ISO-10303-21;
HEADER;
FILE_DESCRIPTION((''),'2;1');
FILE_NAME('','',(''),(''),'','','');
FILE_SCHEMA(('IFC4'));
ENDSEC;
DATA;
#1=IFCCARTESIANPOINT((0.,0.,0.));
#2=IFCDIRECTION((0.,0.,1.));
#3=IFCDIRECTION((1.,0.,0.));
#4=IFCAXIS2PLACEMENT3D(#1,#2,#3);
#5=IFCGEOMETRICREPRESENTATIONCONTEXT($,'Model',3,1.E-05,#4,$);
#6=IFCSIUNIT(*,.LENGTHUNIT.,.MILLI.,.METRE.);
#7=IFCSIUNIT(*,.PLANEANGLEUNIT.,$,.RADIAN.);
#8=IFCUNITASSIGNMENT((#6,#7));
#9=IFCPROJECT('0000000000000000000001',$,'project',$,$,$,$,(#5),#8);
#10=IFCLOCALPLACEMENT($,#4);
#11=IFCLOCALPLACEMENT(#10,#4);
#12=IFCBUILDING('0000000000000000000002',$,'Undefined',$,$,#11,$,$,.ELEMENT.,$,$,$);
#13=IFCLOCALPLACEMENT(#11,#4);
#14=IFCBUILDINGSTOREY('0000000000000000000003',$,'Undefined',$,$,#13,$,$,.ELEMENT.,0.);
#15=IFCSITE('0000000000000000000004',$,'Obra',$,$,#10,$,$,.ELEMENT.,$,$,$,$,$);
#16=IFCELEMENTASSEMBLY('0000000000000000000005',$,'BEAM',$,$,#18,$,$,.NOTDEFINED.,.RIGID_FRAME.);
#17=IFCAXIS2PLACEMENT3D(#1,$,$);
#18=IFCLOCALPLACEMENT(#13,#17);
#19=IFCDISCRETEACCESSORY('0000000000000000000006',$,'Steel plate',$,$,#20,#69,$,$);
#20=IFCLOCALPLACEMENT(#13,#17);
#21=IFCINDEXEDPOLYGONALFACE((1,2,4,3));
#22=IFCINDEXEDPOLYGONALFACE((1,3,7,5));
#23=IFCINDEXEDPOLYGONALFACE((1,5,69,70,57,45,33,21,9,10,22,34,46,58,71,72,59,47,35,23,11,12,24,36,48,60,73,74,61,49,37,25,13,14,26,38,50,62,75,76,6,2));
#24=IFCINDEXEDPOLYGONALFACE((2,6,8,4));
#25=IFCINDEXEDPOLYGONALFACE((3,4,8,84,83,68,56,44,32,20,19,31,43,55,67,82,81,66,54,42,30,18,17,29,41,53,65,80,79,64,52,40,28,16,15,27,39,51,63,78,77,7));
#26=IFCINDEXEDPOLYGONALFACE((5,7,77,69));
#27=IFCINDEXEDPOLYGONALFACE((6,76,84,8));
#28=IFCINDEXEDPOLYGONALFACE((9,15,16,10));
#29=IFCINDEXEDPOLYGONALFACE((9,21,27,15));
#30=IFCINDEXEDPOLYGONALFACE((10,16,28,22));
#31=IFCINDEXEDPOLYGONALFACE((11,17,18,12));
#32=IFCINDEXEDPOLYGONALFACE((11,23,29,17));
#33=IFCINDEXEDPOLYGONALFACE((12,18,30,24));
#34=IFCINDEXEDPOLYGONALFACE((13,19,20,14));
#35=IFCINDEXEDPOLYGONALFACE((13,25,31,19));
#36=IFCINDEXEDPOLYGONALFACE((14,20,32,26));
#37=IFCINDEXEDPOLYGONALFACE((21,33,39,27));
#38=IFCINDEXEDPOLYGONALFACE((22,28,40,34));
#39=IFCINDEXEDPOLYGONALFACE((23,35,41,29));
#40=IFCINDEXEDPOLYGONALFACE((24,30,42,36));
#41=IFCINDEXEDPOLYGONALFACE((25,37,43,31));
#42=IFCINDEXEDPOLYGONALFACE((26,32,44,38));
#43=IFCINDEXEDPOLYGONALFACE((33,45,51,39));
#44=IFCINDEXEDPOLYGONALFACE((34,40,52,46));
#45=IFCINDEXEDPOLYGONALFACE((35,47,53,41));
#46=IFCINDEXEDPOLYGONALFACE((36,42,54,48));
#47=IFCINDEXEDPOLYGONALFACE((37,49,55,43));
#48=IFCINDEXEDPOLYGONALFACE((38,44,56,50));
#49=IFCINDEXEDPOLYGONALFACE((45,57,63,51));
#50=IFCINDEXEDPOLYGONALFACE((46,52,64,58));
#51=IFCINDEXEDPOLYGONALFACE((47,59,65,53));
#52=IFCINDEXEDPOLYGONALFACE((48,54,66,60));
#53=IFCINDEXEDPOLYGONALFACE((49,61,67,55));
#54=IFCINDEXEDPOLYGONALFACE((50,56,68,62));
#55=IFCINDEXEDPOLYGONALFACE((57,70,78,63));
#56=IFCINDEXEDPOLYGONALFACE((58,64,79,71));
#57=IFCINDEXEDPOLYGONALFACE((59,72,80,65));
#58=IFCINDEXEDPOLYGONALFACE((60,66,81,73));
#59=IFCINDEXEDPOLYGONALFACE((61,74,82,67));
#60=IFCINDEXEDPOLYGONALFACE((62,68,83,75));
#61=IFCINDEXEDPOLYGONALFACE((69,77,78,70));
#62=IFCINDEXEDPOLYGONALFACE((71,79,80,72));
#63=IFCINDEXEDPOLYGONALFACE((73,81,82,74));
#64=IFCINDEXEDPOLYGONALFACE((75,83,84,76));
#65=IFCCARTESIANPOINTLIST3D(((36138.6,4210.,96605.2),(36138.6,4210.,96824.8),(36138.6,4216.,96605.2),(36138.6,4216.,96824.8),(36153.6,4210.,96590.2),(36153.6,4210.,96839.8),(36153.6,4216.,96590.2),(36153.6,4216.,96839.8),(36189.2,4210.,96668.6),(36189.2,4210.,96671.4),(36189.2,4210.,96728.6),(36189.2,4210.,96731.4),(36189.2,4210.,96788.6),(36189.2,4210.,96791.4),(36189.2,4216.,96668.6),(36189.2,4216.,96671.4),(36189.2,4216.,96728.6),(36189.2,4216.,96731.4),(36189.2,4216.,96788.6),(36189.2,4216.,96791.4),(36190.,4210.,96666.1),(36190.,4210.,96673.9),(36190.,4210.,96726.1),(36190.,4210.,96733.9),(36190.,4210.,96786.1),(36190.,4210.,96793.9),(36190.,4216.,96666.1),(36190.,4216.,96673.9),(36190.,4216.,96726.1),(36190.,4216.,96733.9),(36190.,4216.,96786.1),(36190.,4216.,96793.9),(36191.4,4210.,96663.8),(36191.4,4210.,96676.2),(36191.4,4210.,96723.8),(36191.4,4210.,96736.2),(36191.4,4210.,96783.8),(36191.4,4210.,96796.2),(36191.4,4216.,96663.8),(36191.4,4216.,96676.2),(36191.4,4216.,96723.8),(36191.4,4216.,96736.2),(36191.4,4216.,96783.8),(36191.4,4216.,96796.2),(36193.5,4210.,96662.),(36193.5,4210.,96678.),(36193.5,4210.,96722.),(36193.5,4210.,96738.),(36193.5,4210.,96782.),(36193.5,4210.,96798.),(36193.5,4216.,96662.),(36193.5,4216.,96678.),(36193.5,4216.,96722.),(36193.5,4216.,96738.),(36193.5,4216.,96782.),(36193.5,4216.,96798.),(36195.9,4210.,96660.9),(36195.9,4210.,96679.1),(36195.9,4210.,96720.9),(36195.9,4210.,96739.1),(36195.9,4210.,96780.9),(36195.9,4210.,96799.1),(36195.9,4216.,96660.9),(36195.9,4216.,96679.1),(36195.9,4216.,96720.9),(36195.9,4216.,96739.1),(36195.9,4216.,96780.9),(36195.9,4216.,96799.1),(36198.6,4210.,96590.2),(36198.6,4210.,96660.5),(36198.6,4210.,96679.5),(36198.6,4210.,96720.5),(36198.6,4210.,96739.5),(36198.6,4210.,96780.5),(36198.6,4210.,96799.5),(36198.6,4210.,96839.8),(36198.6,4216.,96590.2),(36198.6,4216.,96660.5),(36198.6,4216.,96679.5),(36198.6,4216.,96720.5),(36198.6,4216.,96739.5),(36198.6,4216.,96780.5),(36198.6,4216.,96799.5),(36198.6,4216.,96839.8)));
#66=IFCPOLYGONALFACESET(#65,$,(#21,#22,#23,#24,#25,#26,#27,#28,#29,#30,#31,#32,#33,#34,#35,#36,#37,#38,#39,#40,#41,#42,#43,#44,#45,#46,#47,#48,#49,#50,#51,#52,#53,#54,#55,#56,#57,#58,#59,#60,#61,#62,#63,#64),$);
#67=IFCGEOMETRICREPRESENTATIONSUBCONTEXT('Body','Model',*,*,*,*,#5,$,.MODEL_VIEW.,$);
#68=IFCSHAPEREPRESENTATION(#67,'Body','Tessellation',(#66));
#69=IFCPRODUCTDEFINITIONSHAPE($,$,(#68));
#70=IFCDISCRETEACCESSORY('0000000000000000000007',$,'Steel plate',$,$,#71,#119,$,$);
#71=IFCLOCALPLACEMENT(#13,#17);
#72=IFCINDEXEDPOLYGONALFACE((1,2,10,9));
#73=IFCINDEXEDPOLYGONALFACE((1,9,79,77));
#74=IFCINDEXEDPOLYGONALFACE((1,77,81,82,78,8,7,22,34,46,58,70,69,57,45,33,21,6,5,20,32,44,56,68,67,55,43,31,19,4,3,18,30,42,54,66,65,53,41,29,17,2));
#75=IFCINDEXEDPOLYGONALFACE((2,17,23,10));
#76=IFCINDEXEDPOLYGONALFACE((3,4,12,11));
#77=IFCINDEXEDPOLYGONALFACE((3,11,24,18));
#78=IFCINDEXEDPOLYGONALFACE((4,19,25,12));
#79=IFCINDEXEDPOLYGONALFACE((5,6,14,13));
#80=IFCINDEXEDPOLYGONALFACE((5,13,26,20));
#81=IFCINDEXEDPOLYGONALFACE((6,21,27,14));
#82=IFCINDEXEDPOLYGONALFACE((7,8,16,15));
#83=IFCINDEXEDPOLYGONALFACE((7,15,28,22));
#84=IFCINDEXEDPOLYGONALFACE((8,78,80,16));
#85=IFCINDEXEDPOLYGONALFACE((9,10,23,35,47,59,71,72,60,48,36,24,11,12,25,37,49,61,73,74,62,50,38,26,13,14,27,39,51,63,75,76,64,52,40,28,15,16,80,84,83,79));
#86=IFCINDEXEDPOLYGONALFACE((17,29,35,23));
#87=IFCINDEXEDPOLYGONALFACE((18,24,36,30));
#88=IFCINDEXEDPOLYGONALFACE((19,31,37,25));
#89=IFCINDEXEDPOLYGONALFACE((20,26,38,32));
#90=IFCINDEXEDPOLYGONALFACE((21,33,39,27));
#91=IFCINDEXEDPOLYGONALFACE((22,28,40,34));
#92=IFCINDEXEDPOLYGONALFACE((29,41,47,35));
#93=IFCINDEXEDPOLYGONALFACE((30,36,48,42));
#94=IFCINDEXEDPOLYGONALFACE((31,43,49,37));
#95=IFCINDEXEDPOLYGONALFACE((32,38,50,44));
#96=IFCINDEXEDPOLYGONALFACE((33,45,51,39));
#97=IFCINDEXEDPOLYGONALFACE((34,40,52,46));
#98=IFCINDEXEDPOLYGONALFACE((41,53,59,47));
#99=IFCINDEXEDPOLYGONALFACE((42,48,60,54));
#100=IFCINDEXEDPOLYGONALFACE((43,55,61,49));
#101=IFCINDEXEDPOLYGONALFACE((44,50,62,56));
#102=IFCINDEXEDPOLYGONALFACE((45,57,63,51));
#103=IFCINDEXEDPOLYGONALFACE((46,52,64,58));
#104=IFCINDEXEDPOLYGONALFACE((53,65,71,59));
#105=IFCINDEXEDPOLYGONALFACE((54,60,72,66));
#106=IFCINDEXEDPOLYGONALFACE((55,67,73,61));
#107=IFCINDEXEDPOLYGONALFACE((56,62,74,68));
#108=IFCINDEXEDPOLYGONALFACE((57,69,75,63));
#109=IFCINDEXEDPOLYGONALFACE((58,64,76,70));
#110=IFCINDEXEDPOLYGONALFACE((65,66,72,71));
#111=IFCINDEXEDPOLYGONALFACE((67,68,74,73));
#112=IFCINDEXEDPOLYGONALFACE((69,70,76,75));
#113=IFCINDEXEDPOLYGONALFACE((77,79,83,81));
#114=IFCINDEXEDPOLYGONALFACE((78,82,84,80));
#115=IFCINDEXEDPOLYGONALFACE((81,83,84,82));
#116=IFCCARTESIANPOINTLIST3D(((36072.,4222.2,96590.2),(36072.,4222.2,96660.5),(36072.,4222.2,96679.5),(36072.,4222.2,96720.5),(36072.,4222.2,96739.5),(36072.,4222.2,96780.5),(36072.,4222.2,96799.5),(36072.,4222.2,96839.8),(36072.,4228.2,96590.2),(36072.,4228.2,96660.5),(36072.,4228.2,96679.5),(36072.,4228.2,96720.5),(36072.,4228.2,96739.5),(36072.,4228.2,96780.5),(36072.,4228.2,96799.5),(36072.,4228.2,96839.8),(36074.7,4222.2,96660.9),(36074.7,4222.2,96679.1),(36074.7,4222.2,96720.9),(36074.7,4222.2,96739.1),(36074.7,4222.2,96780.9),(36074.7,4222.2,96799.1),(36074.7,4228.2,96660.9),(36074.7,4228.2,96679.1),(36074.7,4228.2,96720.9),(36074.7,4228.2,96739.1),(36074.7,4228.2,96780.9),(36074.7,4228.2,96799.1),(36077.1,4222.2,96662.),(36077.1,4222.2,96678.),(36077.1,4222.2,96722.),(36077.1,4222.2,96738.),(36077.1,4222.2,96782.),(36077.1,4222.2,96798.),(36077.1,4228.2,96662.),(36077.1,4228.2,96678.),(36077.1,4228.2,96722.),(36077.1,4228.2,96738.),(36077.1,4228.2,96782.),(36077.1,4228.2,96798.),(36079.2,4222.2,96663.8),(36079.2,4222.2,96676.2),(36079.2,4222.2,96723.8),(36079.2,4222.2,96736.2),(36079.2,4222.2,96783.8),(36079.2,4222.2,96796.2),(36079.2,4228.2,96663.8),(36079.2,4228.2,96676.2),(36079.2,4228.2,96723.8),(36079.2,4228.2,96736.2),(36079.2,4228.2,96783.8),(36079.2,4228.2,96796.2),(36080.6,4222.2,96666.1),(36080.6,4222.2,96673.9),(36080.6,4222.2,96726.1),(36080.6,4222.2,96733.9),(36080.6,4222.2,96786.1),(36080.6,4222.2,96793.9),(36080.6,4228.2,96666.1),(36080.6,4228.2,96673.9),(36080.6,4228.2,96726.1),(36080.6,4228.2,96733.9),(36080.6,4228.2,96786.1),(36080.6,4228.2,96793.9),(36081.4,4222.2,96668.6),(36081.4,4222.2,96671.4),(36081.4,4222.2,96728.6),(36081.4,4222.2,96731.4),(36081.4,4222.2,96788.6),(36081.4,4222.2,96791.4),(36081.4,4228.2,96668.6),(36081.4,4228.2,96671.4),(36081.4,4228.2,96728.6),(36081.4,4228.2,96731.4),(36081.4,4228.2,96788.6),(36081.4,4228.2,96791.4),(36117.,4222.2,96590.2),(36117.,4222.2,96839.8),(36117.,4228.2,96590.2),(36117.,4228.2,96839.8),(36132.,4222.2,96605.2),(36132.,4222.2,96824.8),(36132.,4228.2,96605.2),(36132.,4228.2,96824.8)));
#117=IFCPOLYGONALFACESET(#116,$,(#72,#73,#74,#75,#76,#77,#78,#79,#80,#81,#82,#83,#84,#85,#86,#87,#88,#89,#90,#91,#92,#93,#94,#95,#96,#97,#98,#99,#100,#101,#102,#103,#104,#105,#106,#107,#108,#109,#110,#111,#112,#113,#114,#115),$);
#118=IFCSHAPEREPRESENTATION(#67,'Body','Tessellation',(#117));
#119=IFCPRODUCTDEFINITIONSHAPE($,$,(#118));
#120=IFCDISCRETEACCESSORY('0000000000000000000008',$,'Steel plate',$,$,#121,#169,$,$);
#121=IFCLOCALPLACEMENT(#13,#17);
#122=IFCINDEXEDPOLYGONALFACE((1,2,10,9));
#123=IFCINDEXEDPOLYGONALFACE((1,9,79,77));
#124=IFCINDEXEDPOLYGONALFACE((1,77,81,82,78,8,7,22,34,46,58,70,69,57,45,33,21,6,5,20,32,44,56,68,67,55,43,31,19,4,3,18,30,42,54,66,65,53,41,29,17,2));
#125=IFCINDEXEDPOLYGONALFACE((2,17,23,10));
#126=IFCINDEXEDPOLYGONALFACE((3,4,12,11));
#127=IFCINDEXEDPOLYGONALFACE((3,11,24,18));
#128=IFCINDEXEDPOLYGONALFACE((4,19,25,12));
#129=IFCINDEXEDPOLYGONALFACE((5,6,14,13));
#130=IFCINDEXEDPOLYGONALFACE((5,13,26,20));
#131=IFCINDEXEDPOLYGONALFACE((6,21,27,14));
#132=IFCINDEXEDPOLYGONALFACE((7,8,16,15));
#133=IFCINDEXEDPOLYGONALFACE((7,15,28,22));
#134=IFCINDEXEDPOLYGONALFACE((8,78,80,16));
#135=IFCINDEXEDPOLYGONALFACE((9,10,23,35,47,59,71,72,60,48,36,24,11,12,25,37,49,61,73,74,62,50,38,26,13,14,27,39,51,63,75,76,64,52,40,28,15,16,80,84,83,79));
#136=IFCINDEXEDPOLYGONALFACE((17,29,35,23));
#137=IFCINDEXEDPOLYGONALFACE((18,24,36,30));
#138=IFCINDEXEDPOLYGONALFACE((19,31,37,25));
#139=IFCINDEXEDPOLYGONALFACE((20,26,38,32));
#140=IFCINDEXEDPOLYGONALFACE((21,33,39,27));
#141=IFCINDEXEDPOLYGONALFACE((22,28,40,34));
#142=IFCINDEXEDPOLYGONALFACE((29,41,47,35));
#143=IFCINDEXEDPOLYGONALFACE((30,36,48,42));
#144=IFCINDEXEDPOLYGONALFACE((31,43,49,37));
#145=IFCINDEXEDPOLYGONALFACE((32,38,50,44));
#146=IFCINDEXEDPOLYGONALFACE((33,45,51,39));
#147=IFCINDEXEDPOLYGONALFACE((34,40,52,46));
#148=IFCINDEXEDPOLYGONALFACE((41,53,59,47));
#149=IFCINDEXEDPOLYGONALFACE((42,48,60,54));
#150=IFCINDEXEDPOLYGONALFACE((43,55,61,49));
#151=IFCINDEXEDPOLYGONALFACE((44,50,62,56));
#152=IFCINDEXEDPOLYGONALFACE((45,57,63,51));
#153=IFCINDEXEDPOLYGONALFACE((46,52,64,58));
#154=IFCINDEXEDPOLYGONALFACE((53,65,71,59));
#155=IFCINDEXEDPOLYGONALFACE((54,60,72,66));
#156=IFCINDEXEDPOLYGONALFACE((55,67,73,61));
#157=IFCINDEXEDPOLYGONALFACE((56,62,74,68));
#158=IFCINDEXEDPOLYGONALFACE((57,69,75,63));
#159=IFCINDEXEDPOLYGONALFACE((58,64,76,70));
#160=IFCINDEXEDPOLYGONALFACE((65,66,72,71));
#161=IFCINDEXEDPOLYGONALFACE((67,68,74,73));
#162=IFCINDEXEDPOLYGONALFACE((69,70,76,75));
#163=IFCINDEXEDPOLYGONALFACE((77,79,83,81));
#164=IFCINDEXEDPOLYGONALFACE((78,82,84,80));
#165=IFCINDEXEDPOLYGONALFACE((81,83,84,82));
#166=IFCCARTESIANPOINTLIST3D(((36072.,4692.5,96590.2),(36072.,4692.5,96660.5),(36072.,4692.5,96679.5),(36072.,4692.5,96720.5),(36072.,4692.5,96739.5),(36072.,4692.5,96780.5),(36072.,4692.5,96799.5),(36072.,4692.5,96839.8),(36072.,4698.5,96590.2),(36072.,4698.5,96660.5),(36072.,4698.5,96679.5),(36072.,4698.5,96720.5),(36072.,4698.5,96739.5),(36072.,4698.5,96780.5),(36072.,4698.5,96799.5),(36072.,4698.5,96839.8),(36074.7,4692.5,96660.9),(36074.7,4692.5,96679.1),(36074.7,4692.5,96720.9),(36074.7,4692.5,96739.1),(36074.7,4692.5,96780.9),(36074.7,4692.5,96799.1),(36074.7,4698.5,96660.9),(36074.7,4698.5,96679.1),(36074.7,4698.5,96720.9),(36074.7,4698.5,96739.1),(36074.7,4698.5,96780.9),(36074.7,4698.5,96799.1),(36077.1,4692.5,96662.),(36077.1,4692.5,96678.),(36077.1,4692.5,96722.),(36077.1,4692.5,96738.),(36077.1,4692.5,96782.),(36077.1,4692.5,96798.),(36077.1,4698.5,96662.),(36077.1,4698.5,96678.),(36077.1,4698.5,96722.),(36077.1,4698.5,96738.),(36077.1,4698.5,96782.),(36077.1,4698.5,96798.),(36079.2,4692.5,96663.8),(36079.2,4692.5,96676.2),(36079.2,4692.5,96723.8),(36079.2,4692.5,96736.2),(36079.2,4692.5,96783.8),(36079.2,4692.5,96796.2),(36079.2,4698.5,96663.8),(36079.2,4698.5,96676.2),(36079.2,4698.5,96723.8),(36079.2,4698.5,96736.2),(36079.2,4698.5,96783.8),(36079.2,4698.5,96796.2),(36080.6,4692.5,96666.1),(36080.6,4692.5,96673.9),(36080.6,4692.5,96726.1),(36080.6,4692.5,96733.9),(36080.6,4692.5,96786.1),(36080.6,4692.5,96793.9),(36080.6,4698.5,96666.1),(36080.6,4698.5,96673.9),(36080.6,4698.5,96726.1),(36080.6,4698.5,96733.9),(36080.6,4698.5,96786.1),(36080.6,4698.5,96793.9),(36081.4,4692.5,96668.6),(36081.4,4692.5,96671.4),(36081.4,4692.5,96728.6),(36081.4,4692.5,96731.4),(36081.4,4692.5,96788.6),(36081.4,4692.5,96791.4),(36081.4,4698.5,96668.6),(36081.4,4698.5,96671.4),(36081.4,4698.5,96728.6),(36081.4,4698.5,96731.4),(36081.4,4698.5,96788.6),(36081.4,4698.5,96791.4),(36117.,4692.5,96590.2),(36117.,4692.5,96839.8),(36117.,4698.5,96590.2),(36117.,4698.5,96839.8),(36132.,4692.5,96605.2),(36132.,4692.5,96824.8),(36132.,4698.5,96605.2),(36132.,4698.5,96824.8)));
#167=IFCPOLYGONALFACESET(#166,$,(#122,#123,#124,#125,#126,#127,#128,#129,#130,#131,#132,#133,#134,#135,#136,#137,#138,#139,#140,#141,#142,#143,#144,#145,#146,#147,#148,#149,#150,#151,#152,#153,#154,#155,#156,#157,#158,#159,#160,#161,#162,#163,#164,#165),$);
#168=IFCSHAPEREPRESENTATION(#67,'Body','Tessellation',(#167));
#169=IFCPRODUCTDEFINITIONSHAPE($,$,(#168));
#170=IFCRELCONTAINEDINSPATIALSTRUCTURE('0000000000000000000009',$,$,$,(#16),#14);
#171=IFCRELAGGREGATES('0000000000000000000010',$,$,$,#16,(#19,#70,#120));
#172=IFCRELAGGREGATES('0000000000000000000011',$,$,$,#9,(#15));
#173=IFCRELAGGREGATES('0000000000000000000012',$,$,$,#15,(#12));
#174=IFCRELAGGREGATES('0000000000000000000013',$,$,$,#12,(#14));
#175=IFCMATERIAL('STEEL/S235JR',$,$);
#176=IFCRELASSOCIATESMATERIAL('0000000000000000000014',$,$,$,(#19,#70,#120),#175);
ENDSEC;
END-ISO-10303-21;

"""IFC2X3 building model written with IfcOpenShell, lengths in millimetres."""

from ifc_helpers import new_model, si_unit, frame, origin_with_axes, origin_2d_with_axis, place, context, subcontext, project, spatial, polyline, circle, outline, extrude, source, transform, mapped, material, element, aggregate, save


model = new_model("IFC2X3")

# Units and contexts
model_context = context("Model", 3, precision=1e-05, world=origin_with_axes())
body_context = subcontext(model_context, "Body", "Model", "MODEL_VIEW")
ifc_project = project(units=[si_unit("LENGTHUNIT", "METRE", prefix="MILLI"), si_unit("PLANEANGLEUNIT", "RADIAN")], contexts=[model_context])

# Site, building, storey
site_placement = place(None, origin_with_axes())
site = spatial("IfcSite", under=ifc_project, at=site_placement, Name="Obra", CompositionType="ELEMENT")
building_placement = place(site_placement, origin_with_axes())
building = spatial("IfcBuilding", under=site, at=building_placement, Name="Undefined", CompositionType="ELEMENT")
storey_placement = place(building_placement, origin_with_axes())
storey = spatial("IfcBuildingStorey", under=building, at=storey_placement, Name="Undefined", CompositionType="ELEMENT", Elevation=0.0)

# Shared definitions
ifc_material = material(Name="STEEL/S235JR")

# Element assembly, discrete accessories, openings
shared_shape = source(origin_with_axes(), body_context, "Body", "SweptSolid", [
    extrude(circle(Radius=9.5, at=origin_2d_with_axis()), frame((0.0, -9.2, 0.0), z_axis=(0.0, 1.0, 0.0), x_axis=(1.0, 0.0, 0.0)), (0.0, 0.0, 1.0), 6.2),
])
assembly_1_placement = place(storey_placement, origin_with_axes())
assembly_1 = element("IfcElementAssembly", 1, at=assembly_1_placement, inside=storey, Name="BEAM", AssemblyPlace="NOTDEFINED", PredefinedType="RIGID_FRAME")
discrete_accessory_1_placement = place(assembly_1_placement, frame((36198.6, 4213.0, 96590.2), z_axis=(0.0, 1.0, 0.0), x_axis=(-1.0, 0.0, 0.0)))
discrete_accessory_1 = element("IfcDiscreteAccessory", 2, at=discrete_accessory_1_placement, material=ifc_material, Name="Steel plate", context=body_context, shape_type="SweptSolid", body=[
    extrude(outline(polyline([(0.0, 0.0), (45.0, 0.0), (60.0, 15.0), (60.0, 234.6), (45.0, 249.6), (0.0, 249.6), (0.0, 0.0)])), frame((0.0, 0.0, -3.0), z_axis=(0.0, 0.0, 1.0), x_axis=(1.0, 0.0, 0.0)), (0.0, 0.0, 1.0), 6.0),
])
opening_1_placement = place(assembly_1_placement, frame((36148.6, 4219.1, 96850.0), z_axis=(1.0, 0.0, 0.0), x_axis=(0.0, 0.0, -1.0)))
element("IfcOpeningElement", 3, at=opening_1_placement, cuts=discrete_accessory_1, ObjectType="Opening", context=body_context, shape_type="MappedRepresentation", body=[
    mapped(shared_shape, transform((60.0, 0.0, 50.0))),
    mapped(shared_shape, transform((120.0, 0.0, 50.0))),
    mapped(shared_shape, transform((180.0, 0.0, 50.0))),
])
discrete_accessory_2_placement = place(assembly_1_placement, frame((36072.0, 4225.2, 96590.2), z_axis=(0.0, -1.0, 0.0), x_axis=(1.0, 0.0, 0.0)))
discrete_accessory_2 = element("IfcDiscreteAccessory", 4, at=discrete_accessory_2_placement, material=ifc_material, Name="Steel plate", context=body_context, shape_type="SweptSolid", body=[
    extrude(outline(polyline([(0.0, 0.0), (45.0, 0.0), (60.0, 15.0), (60.0, 234.6), (45.0, 249.6), (0.0, 249.6), (0.0, 0.0)])), frame((0.0, 0.0, -3.0), z_axis=(0.0, 0.0, 1.0), x_axis=(1.0, 0.0, 0.0)), (0.0, 0.0, 1.0), 6.0),
])
opening_2_placement = place(assembly_1_placement, frame((36122.0, 4219.1, 96850.0), z_axis=(-1.0, 0.0, 0.0), x_axis=(0.0, 0.0, -1.0)))
element("IfcOpeningElement", 5, at=opening_2_placement, cuts=discrete_accessory_2, ObjectType="Opening", context=body_context, shape_type="MappedRepresentation", body=[
    mapped(shared_shape, transform((60.0, 0.0, 50.0))),
    mapped(shared_shape, transform((120.0, 0.0, 50.0))),
    mapped(shared_shape, transform((180.0, 0.0, 50.0))),
])
discrete_accessory_3_placement = place(assembly_1_placement, frame((36072.0, 4695.5, 96590.2), z_axis=(0.0, -1.0, 0.0), x_axis=(1.0, 0.0, 0.0)))
discrete_accessory_3 = element("IfcDiscreteAccessory", 6, at=discrete_accessory_3_placement, material=ifc_material, Name="Steel plate", context=body_context, shape_type="SweptSolid", body=[
    extrude(outline(polyline([(0.0, 0.0), (45.0, 0.0), (60.0, 15.0), (60.0, 234.6), (45.0, 249.6), (0.0, 249.6), (0.0, 0.0)])), frame((0.0, 0.0, -3.0), z_axis=(0.0, 0.0, 1.0), x_axis=(1.0, 0.0, 0.0)), (0.0, 0.0, 1.0), 6.0),
])
opening_3_placement = place(assembly_1_placement, frame((36122.0, 4689.4, 96850.0), z_axis=(-1.0, 0.0, 0.0), x_axis=(0.0, 0.0, -1.0)))
element("IfcOpeningElement", 7, at=opening_3_placement, cuts=discrete_accessory_3, ObjectType="Opening", context=body_context, shape_type="MappedRepresentation", body=[
    mapped(shared_shape, transform((60.0, 0.0, 50.0))),
    mapped(shared_shape, transform((120.0, 0.0, 50.0))),
    mapped(shared_shape, transform((180.0, 0.0, 50.0))),
])
aggregate(assembly_1, [discrete_accessory_1, discrete_accessory_2, discrete_accessory_3])

save(model, "model.ifc")
